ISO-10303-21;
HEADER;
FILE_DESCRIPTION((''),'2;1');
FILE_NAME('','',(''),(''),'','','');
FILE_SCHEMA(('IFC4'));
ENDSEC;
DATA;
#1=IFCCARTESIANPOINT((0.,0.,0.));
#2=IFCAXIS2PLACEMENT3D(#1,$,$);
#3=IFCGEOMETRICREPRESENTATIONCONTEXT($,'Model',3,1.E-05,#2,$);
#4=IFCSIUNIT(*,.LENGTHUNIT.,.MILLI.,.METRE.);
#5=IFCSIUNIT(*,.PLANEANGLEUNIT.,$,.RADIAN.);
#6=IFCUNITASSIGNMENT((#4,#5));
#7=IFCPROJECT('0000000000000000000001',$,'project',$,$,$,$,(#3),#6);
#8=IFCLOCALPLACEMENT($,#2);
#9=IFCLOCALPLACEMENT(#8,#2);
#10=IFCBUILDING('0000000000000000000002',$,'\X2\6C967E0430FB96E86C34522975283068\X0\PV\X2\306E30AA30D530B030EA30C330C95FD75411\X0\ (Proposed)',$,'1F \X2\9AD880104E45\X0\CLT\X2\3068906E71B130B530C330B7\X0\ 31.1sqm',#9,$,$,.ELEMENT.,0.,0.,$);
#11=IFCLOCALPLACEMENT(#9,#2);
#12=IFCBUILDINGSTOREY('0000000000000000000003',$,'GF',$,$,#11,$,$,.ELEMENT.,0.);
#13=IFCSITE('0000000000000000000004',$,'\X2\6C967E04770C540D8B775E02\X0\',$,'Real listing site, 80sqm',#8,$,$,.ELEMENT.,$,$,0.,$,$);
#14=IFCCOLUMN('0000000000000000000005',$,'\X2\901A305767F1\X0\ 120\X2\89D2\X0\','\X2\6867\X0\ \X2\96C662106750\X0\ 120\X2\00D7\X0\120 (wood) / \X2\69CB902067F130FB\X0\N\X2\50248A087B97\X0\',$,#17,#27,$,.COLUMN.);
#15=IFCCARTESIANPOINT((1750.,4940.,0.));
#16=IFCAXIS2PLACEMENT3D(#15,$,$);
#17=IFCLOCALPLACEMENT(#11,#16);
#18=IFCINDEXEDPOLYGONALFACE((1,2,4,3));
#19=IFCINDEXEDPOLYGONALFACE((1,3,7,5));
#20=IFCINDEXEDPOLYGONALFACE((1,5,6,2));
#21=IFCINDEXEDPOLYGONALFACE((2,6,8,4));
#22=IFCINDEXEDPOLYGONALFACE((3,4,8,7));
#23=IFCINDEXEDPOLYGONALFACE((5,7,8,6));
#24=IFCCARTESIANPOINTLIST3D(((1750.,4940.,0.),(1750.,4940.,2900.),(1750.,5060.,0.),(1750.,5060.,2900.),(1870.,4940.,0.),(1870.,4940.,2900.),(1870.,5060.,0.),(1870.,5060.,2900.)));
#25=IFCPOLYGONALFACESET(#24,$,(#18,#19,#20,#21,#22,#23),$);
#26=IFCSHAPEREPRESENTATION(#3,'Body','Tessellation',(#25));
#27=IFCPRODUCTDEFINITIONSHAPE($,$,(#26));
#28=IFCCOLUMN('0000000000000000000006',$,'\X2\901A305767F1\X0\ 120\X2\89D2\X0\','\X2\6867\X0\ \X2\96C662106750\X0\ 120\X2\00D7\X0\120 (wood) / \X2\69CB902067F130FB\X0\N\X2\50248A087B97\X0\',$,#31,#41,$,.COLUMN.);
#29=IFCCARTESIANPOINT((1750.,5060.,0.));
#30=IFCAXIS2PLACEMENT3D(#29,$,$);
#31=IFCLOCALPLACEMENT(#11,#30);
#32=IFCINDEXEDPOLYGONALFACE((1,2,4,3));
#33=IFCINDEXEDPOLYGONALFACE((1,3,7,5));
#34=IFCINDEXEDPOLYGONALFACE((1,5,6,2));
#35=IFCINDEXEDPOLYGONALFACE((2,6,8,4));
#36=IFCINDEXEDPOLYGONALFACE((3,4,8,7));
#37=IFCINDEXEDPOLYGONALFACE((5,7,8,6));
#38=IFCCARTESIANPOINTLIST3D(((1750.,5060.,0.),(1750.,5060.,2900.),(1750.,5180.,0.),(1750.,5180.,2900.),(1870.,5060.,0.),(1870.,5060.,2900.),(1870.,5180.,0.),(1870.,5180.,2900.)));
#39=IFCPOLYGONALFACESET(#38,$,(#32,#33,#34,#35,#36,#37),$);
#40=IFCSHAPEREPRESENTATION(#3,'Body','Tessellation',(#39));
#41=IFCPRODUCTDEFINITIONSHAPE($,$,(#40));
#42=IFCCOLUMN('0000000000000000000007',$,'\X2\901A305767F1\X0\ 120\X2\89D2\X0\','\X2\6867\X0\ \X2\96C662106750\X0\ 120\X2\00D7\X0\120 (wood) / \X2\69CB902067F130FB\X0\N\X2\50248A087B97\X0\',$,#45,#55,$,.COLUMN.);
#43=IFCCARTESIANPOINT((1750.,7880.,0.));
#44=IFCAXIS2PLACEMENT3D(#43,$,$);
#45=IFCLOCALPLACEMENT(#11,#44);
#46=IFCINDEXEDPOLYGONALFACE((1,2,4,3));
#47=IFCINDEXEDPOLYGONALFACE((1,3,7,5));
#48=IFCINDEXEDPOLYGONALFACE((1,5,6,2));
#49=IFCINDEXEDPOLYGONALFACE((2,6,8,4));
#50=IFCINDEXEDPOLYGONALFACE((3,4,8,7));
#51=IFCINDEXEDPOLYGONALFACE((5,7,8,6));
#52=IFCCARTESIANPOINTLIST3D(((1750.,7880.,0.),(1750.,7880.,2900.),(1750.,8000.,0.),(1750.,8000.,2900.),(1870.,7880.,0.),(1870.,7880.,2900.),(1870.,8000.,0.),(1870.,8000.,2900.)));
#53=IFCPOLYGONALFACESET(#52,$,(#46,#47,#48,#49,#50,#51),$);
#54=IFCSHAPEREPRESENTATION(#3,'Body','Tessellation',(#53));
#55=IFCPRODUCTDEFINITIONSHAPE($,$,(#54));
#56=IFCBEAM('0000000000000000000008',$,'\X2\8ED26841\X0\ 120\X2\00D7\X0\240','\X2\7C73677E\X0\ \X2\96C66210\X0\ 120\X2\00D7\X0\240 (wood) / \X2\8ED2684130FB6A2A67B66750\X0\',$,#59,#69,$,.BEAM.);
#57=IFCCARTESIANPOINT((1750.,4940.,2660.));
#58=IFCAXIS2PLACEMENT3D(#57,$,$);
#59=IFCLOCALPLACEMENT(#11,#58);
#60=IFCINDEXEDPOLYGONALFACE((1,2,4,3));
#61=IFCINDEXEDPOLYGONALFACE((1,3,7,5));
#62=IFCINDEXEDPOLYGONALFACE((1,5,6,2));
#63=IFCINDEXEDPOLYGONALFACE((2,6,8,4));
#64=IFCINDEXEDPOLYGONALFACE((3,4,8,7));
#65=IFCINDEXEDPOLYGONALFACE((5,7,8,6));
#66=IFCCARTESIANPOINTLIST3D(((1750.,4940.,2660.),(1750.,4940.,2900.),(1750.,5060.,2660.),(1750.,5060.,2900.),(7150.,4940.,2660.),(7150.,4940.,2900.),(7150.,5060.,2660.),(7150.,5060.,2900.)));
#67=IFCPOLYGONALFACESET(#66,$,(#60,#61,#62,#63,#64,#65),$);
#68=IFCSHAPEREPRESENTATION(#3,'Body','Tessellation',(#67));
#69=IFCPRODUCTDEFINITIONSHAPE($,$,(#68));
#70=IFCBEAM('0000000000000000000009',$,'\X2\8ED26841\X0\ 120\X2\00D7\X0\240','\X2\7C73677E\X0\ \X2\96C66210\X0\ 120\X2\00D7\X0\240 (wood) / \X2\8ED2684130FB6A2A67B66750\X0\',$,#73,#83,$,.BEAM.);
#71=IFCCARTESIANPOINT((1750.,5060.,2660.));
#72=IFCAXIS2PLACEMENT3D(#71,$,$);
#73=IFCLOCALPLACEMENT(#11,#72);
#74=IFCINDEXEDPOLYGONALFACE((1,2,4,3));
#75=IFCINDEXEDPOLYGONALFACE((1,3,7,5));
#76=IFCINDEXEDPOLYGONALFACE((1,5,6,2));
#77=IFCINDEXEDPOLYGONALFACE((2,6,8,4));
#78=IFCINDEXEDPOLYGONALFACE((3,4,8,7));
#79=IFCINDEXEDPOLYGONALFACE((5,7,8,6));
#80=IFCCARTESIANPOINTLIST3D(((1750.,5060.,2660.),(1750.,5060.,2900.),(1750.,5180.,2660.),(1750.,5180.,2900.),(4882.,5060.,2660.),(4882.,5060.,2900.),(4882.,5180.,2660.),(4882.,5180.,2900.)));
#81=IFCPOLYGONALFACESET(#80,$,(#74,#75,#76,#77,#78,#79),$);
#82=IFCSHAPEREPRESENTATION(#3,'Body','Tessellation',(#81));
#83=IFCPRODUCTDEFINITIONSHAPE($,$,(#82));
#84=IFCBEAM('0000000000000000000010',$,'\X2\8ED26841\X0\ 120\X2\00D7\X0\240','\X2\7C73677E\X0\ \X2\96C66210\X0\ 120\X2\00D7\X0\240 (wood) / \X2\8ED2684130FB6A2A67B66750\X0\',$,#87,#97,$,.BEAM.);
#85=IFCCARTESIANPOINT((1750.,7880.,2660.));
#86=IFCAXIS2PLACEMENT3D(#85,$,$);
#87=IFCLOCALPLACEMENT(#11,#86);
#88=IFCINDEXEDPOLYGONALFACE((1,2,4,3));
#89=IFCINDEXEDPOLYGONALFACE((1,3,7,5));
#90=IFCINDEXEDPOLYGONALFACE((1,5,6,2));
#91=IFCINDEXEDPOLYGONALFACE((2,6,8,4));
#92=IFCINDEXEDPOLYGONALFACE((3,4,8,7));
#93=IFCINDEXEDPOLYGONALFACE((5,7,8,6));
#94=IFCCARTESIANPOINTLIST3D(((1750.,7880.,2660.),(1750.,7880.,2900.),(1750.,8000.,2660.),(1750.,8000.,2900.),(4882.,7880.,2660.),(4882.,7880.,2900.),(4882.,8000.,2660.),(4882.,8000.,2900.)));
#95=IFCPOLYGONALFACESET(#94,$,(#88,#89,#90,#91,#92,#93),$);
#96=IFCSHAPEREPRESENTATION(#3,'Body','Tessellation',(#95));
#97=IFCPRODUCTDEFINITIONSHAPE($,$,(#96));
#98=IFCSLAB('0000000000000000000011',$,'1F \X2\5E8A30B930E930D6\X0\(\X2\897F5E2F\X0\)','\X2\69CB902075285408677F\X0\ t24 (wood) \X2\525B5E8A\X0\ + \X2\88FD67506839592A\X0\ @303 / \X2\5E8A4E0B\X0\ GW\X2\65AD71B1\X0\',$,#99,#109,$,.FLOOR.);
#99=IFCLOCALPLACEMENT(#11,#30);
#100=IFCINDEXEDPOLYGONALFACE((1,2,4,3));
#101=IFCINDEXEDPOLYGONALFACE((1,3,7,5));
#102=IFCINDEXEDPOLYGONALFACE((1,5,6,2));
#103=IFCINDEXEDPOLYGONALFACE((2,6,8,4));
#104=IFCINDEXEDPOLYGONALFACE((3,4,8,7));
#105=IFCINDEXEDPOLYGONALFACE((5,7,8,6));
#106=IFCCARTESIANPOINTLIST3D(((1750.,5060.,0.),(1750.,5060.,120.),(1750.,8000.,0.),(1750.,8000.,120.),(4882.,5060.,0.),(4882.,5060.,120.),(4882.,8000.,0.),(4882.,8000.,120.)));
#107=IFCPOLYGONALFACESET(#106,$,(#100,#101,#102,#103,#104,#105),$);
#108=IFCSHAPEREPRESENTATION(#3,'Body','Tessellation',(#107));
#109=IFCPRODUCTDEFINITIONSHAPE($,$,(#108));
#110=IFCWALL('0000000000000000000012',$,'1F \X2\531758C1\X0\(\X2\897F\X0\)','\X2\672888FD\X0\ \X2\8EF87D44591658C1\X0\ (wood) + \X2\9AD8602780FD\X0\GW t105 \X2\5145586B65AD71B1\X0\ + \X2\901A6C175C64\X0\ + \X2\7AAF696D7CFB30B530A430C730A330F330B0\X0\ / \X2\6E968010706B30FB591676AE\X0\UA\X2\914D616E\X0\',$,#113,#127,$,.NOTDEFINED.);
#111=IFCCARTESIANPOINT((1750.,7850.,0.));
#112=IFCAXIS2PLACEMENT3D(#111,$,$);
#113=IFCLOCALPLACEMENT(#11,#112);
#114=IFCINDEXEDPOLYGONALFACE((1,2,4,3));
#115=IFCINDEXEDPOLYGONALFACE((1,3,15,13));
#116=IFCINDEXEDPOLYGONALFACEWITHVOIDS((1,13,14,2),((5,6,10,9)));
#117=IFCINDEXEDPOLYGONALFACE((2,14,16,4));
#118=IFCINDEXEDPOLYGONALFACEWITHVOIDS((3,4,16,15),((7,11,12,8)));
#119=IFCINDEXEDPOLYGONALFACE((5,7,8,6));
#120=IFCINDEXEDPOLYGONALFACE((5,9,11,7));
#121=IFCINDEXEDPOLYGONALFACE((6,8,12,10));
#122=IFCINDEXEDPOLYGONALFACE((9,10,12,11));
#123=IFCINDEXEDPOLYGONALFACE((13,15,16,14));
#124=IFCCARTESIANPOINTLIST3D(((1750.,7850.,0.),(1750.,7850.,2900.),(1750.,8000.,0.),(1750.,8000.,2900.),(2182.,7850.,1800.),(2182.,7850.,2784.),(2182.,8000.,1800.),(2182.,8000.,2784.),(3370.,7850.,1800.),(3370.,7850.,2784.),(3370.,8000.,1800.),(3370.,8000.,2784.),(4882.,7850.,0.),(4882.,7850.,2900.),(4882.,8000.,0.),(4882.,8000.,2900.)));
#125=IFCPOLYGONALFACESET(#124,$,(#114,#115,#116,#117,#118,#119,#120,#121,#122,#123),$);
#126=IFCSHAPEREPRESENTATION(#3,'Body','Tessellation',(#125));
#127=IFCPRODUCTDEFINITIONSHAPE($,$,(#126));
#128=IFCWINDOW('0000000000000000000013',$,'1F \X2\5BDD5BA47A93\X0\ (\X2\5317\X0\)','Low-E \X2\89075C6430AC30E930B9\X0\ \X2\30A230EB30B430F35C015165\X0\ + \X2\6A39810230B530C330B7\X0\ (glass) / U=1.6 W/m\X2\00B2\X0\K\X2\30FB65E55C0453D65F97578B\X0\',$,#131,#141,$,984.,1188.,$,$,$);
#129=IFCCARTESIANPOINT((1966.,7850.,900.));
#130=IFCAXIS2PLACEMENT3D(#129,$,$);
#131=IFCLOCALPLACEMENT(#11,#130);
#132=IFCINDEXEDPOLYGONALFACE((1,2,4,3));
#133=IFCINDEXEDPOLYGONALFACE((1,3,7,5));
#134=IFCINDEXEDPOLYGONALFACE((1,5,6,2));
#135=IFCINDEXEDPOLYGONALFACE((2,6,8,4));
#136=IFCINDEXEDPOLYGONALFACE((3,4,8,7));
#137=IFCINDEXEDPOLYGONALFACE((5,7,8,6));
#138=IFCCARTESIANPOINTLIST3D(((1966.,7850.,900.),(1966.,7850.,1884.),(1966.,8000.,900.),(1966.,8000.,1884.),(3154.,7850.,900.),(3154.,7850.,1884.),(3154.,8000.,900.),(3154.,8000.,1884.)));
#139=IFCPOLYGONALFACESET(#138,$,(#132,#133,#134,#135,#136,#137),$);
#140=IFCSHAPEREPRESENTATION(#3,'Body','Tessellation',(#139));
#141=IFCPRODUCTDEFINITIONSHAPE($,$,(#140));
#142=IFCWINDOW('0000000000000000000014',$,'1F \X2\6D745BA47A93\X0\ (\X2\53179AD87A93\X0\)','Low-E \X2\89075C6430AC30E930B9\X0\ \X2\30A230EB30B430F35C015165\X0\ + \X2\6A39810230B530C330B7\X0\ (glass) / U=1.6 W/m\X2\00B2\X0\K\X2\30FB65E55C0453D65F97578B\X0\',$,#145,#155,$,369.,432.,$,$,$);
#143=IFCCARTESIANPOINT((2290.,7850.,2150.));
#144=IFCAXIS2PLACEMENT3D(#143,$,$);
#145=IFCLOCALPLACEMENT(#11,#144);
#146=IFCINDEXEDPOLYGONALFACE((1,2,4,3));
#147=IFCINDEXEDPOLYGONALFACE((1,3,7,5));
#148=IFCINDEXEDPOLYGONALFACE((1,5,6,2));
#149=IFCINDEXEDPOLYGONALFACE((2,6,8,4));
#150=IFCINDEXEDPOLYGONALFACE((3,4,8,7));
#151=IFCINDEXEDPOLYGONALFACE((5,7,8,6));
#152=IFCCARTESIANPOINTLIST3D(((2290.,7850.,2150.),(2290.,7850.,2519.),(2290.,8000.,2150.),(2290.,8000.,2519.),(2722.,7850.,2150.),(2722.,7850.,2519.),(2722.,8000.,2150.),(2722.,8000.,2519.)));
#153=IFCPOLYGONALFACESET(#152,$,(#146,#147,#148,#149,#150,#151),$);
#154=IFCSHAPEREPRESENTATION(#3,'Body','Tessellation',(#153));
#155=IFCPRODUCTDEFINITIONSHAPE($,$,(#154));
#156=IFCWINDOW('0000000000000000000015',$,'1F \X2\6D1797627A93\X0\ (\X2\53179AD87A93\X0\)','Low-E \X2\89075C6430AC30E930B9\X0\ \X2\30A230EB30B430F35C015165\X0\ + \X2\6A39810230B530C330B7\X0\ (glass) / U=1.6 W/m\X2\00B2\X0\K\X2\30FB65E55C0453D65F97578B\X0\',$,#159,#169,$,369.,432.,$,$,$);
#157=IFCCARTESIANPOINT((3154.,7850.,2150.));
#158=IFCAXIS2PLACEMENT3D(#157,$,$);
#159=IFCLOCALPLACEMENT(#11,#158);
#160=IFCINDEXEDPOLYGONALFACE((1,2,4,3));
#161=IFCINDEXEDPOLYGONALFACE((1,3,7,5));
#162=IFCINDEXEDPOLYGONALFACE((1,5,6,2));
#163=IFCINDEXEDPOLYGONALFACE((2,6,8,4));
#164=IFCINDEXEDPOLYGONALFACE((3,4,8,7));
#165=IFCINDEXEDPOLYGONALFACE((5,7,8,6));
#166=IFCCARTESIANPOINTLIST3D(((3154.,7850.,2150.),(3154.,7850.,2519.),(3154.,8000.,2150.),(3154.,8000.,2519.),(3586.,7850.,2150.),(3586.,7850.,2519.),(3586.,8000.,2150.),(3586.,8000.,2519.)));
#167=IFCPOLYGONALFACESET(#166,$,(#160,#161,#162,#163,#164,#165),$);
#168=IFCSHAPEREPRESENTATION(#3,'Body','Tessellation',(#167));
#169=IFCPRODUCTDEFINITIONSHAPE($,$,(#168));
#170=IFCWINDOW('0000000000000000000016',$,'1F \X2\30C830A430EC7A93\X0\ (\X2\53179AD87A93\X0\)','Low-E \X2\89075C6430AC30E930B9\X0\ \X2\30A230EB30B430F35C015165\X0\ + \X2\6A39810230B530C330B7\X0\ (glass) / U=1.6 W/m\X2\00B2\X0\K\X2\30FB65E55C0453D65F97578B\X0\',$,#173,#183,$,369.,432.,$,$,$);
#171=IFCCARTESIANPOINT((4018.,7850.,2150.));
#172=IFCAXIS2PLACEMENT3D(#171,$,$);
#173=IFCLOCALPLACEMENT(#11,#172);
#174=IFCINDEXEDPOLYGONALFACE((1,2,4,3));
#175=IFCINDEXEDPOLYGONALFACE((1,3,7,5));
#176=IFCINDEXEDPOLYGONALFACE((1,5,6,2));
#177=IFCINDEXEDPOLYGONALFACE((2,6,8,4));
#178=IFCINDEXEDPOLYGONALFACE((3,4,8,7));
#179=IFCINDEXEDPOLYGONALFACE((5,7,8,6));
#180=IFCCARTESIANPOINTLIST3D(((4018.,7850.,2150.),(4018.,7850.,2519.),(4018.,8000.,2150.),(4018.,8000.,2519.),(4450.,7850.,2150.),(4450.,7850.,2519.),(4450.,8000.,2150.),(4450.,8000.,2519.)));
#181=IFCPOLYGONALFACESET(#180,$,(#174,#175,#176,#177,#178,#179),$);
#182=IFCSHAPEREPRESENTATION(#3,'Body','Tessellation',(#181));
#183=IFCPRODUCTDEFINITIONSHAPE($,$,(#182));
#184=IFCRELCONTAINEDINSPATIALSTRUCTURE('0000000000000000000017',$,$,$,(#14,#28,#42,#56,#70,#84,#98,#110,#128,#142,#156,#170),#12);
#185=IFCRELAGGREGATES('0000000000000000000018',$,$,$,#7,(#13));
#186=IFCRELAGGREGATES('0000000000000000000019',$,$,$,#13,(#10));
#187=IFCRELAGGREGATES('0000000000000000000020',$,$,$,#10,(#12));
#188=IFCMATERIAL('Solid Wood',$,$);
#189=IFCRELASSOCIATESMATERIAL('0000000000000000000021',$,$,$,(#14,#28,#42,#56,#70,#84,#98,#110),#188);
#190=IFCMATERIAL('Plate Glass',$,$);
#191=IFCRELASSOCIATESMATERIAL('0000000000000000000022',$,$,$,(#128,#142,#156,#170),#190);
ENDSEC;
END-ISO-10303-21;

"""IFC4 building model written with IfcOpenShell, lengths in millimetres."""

from ifc_helpers import new_model, si_unit, frame, frame_2d, origin, place, context, project, spatial, rectangle, extrude, material, element, fill, save


model = new_model("IFC4")

# Units and contexts
model_context = context("Model", 3, precision=1e-05, world=origin())
ifc_project = project(units=[si_unit("LENGTHUNIT", "METRE", prefix="MILLI"), si_unit("PLANEANGLEUNIT", "RADIAN")], contexts=[model_context])

# Site, building, storey
site_placement = place(None, origin())
site = spatial("IfcSite", under=ifc_project, at=site_placement, Name="沖縄県名護市", ObjectType="Real listing site, 80sqm", CompositionType="ELEMENT", RefElevation=0.0)
building_placement = place(site_placement, origin())
building = spatial("IfcBuilding", under=site, at=building_placement, Name="沖縄・雨水利用とPVのオフグリッド志向 (Proposed)", ObjectType="1F 高耐久CLTと遮熱サッシ 31.1sqm", CompositionType="ELEMENT", ElevationOfRefHeight=0.0, ElevationOfTerrain=0.0)
storey_placement = place(building_placement, origin())
storey = spatial("IfcBuildingStorey", under=building, at=storey_placement, Name="GF", CompositionType="ELEMENT", Elevation=0.0)

# Columns
ifc_material_1 = material(Name="Solid Wood")
column_1_placement = place(storey_placement, frame((1750.0, 4940.0, 0.0)))
element("IfcColumn", 1, at=column_1_placement, inside=storey, material=ifc_material_1, Name="通し柱 120角", Description="桧 集成材 120×120 (wood) / 構造柱・N値計算", PredefinedType="COLUMN", context=model_context, shape_type="SweptSolid", body=[
    extrude(rectangle(XDim=120.0, YDim=120.0, at=frame_2d((60.0, 60.0))), frame((1750.0, 4940.0, 0.0)), (0.0, 0.0, 1.0), 2900.0),
])
column_2_placement = place(storey_placement, frame((1750.0, 5060.0, 0.0)))
element("IfcColumn", 2, at=column_2_placement, inside=storey, material=ifc_material_1, Name="通し柱 120角", Description="桧 集成材 120×120 (wood) / 構造柱・N値計算", PredefinedType="COLUMN", context=model_context, shape_type="SweptSolid", body=[
    extrude(rectangle(XDim=120.0, YDim=120.0, at=frame_2d((60.0, 60.0))), frame((1750.0, 5060.0, 0.0)), (0.0, 0.0, 1.0), 2900.0),
])
column_3_placement = place(storey_placement, frame((1750.0, 7880.0, 0.0)))
element("IfcColumn", 3, at=column_3_placement, inside=storey, material=ifc_material_1, Name="通し柱 120角", Description="桧 集成材 120×120 (wood) / 構造柱・N値計算", PredefinedType="COLUMN", context=model_context, shape_type="SweptSolid", body=[
    extrude(rectangle(XDim=120.0, YDim=120.0, at=frame_2d((60.0, 60.0))), frame((1750.0, 7880.0, 0.0)), (0.0, 0.0, 1.0), 2900.0),
])

# Beams
beam_1_placement = place(storey_placement, frame((1750.0, 4940.0, 2660.0)))
element("IfcBeam", 4, at=beam_1_placement, inside=storey, material=ifc_material_1, Name="軒桁 120×240", Description="米松 集成 120×240 (wood) / 軒桁・横架材", PredefinedType="BEAM", context=model_context, shape_type="SweptSolid", body=[
    extrude(rectangle(XDim=5400.0, YDim=120.0, at=frame_2d((2700.0, 60.0))), frame((1750.0, 4940.0, 2660.0)), (0.0, 0.0, 1.0), 240.0),
])
beam_2_placement = place(storey_placement, frame((1750.0, 5060.0, 2660.0)))
element("IfcBeam", 5, at=beam_2_placement, inside=storey, material=ifc_material_1, Name="軒桁 120×240", Description="米松 集成 120×240 (wood) / 軒桁・横架材", PredefinedType="BEAM", context=model_context, shape_type="SweptSolid", body=[
    extrude(rectangle(XDim=3132.0, YDim=120.0, at=frame_2d((1566.0, 60.0))), frame((1750.0, 5060.0, 2660.0)), (0.0, 0.0, 1.0), 240.0),
])
beam_3_placement = place(storey_placement, frame((1750.0, 7880.0, 2660.0)))
element("IfcBeam", 6, at=beam_3_placement, inside=storey, material=ifc_material_1, Name="軒桁 120×240", Description="米松 集成 120×240 (wood) / 軒桁・横架材", PredefinedType="BEAM", context=model_context, shape_type="SweptSolid", body=[
    extrude(rectangle(XDim=3132.0, YDim=120.0, at=frame_2d((1566.0, 60.0))), frame((1750.0, 7880.0, 2660.0)), (0.0, 0.0, 1.0), 240.0),
])

# Slab
slab_placement = place(storey_placement, frame((1750.0, 5060.0, 0.0)))
element("IfcSlab", 7, at=slab_placement, inside=storey, material=ifc_material_1, Name="1F 床スラブ(西帯)", Description="構造用合板 t24 (wood) 剛床 + 製材根太 @303 / 床下 GW断熱", PredefinedType="FLOOR", context=model_context, shape_type="SweptSolid", body=[
    extrude(rectangle(XDim=3132.0, YDim=2940.0, at=frame_2d((1566.0, 1470.0))), frame((1750.0, 5060.0, 0.0)), (0.0, 0.0, 1.0), 120.0),
])

# Wall, openings, windows
wall_1_placement = place(storey_placement, frame((1750.0, 7850.0, 0.0)))
wall_1 = element("IfcWall", 8, at=wall_1_placement, inside=storey, material=ifc_material_1, Name="1F 北壁(西)", Description="木製 軸組外壁 (wood) + 高性能GW t105 充填断熱 + 通気層 + 窯業系サイディング / 準耐火・外皮UA配慮", PredefinedType="NOTDEFINED", context=model_context, shape_type="SweptSolid", body=[
    extrude(rectangle(XDim=3132.0, YDim=150.0, at=frame_2d((1566.0, 75.0))), frame((1750.0, 7850.0, 0.0)), (0.0, 0.0, 1.0), 2900.0),
])
opening_1_placement = place(storey_placement, frame((1966.0, 7850.0, 900.0)))
opening_1 = element("IfcOpeningElement", 9, at=opening_1_placement, cuts=wall_1, PredefinedType="NOTDEFINED", context=model_context, shape_type="SweptSolid", body=[
    extrude(rectangle(XDim=1188.0, YDim=150.0, at=frame_2d((594.0, 75.0))), frame((1966.0, 7850.0, 900.0)), (0.0, 0.0, 1.0), 984.0),
])
opening_2_placement = place(storey_placement, frame((2290.0, 7850.0, 2150.0)))
opening_2 = element("IfcOpeningElement", 10, at=opening_2_placement, cuts=wall_1, PredefinedType="NOTDEFINED", context=model_context, shape_type="SweptSolid", body=[
    extrude(rectangle(XDim=432.0, YDim=150.0, at=frame_2d((216.0, 75.0))), frame((2290.0, 7850.0, 2150.0)), (0.0, 0.0, 1.0), 369.0),
])
opening_3_placement = place(storey_placement, frame((3154.0, 7850.0, 2150.0)))
opening_3 = element("IfcOpeningElement", 11, at=opening_3_placement, cuts=wall_1, PredefinedType="NOTDEFINED", context=model_context, shape_type="SweptSolid", body=[
    extrude(rectangle(XDim=432.0, YDim=150.0, at=frame_2d((216.0, 75.0))), frame((3154.0, 7850.0, 2150.0)), (0.0, 0.0, 1.0), 369.0),
])
opening_4_placement = place(storey_placement, frame((4018.0, 7850.0, 2150.0)))
opening_4 = element("IfcOpeningElement", 12, at=opening_4_placement, cuts=wall_1, PredefinedType="NOTDEFINED", context=model_context, shape_type="SweptSolid", body=[
    extrude(rectangle(XDim=432.0, YDim=150.0, at=frame_2d((216.0, 75.0))), frame((4018.0, 7850.0, 2150.0)), (0.0, 0.0, 1.0), 369.0),
])
ifc_material_2 = material(Name="Plate Glass")
window_1_placement = place(storey_placement, frame((1966.0, 7850.0, 900.0)))
window_1 = element("IfcWindow", 13, at=window_1_placement, inside=storey, material=ifc_material_2, Name="1F 寝室窓 (北)", Description="Low-E 複層ガラス アルゴン封入 + 樹脂サッシ (glass) / U=1.6 W/m²K・日射取得型", OverallHeight=984.0, OverallWidth=1188.0, context=model_context, shape_type="SweptSolid", body=[
    extrude(rectangle(XDim=1188.0, YDim=150.0, at=frame_2d((594.0, 75.0))), frame((1966.0, 7850.0, 900.0)), (0.0, 0.0, 1.0), 984.0),
])
fill(opening_1, window_1)
window_2_placement = place(storey_placement, frame((2290.0, 7850.0, 2150.0)))
window_2 = element("IfcWindow", 14, at=window_2_placement, inside=storey, material=ifc_material_2, Name="1F 浴室窓 (北高窓)", Description="Low-E 複層ガラス アルゴン封入 + 樹脂サッシ (glass) / U=1.6 W/m²K・日射取得型", OverallHeight=369.0, OverallWidth=432.0, context=model_context, shape_type="SweptSolid", body=[
    extrude(rectangle(XDim=432.0, YDim=150.0, at=frame_2d((216.0, 75.0))), frame((2290.0, 7850.0, 2150.0)), (0.0, 0.0, 1.0), 369.0),
])
fill(opening_2, window_2)
window_3_placement = place(storey_placement, frame((3154.0, 7850.0, 2150.0)))
window_3 = element("IfcWindow", 15, at=window_3_placement, inside=storey, material=ifc_material_2, Name="1F 洗面窓 (北高窓)", Description="Low-E 複層ガラス アルゴン封入 + 樹脂サッシ (glass) / U=1.6 W/m²K・日射取得型", OverallHeight=369.0, OverallWidth=432.0, context=model_context, shape_type="SweptSolid", body=[
    extrude(rectangle(XDim=432.0, YDim=150.0, at=frame_2d((216.0, 75.0))), frame((3154.0, 7850.0, 2150.0)), (0.0, 0.0, 1.0), 369.0),
])
fill(opening_3, window_3)
window_4_placement = place(storey_placement, frame((4018.0, 7850.0, 2150.0)))
window_4 = element("IfcWindow", 16, at=window_4_placement, inside=storey, material=ifc_material_2, Name="1F トイレ窓 (北高窓)", Description="Low-E 複層ガラス アルゴン封入 + 樹脂サッシ (glass) / U=1.6 W/m²K・日射取得型", OverallHeight=369.0, OverallWidth=432.0, context=model_context, shape_type="SweptSolid", body=[
    extrude(rectangle(XDim=432.0, YDim=150.0, at=frame_2d((216.0, 75.0))), frame((4018.0, 7850.0, 2150.0)), (0.0, 0.0, 1.0), 369.0),
])
fill(opening_4, window_4)

save(model, "model.ifc")
